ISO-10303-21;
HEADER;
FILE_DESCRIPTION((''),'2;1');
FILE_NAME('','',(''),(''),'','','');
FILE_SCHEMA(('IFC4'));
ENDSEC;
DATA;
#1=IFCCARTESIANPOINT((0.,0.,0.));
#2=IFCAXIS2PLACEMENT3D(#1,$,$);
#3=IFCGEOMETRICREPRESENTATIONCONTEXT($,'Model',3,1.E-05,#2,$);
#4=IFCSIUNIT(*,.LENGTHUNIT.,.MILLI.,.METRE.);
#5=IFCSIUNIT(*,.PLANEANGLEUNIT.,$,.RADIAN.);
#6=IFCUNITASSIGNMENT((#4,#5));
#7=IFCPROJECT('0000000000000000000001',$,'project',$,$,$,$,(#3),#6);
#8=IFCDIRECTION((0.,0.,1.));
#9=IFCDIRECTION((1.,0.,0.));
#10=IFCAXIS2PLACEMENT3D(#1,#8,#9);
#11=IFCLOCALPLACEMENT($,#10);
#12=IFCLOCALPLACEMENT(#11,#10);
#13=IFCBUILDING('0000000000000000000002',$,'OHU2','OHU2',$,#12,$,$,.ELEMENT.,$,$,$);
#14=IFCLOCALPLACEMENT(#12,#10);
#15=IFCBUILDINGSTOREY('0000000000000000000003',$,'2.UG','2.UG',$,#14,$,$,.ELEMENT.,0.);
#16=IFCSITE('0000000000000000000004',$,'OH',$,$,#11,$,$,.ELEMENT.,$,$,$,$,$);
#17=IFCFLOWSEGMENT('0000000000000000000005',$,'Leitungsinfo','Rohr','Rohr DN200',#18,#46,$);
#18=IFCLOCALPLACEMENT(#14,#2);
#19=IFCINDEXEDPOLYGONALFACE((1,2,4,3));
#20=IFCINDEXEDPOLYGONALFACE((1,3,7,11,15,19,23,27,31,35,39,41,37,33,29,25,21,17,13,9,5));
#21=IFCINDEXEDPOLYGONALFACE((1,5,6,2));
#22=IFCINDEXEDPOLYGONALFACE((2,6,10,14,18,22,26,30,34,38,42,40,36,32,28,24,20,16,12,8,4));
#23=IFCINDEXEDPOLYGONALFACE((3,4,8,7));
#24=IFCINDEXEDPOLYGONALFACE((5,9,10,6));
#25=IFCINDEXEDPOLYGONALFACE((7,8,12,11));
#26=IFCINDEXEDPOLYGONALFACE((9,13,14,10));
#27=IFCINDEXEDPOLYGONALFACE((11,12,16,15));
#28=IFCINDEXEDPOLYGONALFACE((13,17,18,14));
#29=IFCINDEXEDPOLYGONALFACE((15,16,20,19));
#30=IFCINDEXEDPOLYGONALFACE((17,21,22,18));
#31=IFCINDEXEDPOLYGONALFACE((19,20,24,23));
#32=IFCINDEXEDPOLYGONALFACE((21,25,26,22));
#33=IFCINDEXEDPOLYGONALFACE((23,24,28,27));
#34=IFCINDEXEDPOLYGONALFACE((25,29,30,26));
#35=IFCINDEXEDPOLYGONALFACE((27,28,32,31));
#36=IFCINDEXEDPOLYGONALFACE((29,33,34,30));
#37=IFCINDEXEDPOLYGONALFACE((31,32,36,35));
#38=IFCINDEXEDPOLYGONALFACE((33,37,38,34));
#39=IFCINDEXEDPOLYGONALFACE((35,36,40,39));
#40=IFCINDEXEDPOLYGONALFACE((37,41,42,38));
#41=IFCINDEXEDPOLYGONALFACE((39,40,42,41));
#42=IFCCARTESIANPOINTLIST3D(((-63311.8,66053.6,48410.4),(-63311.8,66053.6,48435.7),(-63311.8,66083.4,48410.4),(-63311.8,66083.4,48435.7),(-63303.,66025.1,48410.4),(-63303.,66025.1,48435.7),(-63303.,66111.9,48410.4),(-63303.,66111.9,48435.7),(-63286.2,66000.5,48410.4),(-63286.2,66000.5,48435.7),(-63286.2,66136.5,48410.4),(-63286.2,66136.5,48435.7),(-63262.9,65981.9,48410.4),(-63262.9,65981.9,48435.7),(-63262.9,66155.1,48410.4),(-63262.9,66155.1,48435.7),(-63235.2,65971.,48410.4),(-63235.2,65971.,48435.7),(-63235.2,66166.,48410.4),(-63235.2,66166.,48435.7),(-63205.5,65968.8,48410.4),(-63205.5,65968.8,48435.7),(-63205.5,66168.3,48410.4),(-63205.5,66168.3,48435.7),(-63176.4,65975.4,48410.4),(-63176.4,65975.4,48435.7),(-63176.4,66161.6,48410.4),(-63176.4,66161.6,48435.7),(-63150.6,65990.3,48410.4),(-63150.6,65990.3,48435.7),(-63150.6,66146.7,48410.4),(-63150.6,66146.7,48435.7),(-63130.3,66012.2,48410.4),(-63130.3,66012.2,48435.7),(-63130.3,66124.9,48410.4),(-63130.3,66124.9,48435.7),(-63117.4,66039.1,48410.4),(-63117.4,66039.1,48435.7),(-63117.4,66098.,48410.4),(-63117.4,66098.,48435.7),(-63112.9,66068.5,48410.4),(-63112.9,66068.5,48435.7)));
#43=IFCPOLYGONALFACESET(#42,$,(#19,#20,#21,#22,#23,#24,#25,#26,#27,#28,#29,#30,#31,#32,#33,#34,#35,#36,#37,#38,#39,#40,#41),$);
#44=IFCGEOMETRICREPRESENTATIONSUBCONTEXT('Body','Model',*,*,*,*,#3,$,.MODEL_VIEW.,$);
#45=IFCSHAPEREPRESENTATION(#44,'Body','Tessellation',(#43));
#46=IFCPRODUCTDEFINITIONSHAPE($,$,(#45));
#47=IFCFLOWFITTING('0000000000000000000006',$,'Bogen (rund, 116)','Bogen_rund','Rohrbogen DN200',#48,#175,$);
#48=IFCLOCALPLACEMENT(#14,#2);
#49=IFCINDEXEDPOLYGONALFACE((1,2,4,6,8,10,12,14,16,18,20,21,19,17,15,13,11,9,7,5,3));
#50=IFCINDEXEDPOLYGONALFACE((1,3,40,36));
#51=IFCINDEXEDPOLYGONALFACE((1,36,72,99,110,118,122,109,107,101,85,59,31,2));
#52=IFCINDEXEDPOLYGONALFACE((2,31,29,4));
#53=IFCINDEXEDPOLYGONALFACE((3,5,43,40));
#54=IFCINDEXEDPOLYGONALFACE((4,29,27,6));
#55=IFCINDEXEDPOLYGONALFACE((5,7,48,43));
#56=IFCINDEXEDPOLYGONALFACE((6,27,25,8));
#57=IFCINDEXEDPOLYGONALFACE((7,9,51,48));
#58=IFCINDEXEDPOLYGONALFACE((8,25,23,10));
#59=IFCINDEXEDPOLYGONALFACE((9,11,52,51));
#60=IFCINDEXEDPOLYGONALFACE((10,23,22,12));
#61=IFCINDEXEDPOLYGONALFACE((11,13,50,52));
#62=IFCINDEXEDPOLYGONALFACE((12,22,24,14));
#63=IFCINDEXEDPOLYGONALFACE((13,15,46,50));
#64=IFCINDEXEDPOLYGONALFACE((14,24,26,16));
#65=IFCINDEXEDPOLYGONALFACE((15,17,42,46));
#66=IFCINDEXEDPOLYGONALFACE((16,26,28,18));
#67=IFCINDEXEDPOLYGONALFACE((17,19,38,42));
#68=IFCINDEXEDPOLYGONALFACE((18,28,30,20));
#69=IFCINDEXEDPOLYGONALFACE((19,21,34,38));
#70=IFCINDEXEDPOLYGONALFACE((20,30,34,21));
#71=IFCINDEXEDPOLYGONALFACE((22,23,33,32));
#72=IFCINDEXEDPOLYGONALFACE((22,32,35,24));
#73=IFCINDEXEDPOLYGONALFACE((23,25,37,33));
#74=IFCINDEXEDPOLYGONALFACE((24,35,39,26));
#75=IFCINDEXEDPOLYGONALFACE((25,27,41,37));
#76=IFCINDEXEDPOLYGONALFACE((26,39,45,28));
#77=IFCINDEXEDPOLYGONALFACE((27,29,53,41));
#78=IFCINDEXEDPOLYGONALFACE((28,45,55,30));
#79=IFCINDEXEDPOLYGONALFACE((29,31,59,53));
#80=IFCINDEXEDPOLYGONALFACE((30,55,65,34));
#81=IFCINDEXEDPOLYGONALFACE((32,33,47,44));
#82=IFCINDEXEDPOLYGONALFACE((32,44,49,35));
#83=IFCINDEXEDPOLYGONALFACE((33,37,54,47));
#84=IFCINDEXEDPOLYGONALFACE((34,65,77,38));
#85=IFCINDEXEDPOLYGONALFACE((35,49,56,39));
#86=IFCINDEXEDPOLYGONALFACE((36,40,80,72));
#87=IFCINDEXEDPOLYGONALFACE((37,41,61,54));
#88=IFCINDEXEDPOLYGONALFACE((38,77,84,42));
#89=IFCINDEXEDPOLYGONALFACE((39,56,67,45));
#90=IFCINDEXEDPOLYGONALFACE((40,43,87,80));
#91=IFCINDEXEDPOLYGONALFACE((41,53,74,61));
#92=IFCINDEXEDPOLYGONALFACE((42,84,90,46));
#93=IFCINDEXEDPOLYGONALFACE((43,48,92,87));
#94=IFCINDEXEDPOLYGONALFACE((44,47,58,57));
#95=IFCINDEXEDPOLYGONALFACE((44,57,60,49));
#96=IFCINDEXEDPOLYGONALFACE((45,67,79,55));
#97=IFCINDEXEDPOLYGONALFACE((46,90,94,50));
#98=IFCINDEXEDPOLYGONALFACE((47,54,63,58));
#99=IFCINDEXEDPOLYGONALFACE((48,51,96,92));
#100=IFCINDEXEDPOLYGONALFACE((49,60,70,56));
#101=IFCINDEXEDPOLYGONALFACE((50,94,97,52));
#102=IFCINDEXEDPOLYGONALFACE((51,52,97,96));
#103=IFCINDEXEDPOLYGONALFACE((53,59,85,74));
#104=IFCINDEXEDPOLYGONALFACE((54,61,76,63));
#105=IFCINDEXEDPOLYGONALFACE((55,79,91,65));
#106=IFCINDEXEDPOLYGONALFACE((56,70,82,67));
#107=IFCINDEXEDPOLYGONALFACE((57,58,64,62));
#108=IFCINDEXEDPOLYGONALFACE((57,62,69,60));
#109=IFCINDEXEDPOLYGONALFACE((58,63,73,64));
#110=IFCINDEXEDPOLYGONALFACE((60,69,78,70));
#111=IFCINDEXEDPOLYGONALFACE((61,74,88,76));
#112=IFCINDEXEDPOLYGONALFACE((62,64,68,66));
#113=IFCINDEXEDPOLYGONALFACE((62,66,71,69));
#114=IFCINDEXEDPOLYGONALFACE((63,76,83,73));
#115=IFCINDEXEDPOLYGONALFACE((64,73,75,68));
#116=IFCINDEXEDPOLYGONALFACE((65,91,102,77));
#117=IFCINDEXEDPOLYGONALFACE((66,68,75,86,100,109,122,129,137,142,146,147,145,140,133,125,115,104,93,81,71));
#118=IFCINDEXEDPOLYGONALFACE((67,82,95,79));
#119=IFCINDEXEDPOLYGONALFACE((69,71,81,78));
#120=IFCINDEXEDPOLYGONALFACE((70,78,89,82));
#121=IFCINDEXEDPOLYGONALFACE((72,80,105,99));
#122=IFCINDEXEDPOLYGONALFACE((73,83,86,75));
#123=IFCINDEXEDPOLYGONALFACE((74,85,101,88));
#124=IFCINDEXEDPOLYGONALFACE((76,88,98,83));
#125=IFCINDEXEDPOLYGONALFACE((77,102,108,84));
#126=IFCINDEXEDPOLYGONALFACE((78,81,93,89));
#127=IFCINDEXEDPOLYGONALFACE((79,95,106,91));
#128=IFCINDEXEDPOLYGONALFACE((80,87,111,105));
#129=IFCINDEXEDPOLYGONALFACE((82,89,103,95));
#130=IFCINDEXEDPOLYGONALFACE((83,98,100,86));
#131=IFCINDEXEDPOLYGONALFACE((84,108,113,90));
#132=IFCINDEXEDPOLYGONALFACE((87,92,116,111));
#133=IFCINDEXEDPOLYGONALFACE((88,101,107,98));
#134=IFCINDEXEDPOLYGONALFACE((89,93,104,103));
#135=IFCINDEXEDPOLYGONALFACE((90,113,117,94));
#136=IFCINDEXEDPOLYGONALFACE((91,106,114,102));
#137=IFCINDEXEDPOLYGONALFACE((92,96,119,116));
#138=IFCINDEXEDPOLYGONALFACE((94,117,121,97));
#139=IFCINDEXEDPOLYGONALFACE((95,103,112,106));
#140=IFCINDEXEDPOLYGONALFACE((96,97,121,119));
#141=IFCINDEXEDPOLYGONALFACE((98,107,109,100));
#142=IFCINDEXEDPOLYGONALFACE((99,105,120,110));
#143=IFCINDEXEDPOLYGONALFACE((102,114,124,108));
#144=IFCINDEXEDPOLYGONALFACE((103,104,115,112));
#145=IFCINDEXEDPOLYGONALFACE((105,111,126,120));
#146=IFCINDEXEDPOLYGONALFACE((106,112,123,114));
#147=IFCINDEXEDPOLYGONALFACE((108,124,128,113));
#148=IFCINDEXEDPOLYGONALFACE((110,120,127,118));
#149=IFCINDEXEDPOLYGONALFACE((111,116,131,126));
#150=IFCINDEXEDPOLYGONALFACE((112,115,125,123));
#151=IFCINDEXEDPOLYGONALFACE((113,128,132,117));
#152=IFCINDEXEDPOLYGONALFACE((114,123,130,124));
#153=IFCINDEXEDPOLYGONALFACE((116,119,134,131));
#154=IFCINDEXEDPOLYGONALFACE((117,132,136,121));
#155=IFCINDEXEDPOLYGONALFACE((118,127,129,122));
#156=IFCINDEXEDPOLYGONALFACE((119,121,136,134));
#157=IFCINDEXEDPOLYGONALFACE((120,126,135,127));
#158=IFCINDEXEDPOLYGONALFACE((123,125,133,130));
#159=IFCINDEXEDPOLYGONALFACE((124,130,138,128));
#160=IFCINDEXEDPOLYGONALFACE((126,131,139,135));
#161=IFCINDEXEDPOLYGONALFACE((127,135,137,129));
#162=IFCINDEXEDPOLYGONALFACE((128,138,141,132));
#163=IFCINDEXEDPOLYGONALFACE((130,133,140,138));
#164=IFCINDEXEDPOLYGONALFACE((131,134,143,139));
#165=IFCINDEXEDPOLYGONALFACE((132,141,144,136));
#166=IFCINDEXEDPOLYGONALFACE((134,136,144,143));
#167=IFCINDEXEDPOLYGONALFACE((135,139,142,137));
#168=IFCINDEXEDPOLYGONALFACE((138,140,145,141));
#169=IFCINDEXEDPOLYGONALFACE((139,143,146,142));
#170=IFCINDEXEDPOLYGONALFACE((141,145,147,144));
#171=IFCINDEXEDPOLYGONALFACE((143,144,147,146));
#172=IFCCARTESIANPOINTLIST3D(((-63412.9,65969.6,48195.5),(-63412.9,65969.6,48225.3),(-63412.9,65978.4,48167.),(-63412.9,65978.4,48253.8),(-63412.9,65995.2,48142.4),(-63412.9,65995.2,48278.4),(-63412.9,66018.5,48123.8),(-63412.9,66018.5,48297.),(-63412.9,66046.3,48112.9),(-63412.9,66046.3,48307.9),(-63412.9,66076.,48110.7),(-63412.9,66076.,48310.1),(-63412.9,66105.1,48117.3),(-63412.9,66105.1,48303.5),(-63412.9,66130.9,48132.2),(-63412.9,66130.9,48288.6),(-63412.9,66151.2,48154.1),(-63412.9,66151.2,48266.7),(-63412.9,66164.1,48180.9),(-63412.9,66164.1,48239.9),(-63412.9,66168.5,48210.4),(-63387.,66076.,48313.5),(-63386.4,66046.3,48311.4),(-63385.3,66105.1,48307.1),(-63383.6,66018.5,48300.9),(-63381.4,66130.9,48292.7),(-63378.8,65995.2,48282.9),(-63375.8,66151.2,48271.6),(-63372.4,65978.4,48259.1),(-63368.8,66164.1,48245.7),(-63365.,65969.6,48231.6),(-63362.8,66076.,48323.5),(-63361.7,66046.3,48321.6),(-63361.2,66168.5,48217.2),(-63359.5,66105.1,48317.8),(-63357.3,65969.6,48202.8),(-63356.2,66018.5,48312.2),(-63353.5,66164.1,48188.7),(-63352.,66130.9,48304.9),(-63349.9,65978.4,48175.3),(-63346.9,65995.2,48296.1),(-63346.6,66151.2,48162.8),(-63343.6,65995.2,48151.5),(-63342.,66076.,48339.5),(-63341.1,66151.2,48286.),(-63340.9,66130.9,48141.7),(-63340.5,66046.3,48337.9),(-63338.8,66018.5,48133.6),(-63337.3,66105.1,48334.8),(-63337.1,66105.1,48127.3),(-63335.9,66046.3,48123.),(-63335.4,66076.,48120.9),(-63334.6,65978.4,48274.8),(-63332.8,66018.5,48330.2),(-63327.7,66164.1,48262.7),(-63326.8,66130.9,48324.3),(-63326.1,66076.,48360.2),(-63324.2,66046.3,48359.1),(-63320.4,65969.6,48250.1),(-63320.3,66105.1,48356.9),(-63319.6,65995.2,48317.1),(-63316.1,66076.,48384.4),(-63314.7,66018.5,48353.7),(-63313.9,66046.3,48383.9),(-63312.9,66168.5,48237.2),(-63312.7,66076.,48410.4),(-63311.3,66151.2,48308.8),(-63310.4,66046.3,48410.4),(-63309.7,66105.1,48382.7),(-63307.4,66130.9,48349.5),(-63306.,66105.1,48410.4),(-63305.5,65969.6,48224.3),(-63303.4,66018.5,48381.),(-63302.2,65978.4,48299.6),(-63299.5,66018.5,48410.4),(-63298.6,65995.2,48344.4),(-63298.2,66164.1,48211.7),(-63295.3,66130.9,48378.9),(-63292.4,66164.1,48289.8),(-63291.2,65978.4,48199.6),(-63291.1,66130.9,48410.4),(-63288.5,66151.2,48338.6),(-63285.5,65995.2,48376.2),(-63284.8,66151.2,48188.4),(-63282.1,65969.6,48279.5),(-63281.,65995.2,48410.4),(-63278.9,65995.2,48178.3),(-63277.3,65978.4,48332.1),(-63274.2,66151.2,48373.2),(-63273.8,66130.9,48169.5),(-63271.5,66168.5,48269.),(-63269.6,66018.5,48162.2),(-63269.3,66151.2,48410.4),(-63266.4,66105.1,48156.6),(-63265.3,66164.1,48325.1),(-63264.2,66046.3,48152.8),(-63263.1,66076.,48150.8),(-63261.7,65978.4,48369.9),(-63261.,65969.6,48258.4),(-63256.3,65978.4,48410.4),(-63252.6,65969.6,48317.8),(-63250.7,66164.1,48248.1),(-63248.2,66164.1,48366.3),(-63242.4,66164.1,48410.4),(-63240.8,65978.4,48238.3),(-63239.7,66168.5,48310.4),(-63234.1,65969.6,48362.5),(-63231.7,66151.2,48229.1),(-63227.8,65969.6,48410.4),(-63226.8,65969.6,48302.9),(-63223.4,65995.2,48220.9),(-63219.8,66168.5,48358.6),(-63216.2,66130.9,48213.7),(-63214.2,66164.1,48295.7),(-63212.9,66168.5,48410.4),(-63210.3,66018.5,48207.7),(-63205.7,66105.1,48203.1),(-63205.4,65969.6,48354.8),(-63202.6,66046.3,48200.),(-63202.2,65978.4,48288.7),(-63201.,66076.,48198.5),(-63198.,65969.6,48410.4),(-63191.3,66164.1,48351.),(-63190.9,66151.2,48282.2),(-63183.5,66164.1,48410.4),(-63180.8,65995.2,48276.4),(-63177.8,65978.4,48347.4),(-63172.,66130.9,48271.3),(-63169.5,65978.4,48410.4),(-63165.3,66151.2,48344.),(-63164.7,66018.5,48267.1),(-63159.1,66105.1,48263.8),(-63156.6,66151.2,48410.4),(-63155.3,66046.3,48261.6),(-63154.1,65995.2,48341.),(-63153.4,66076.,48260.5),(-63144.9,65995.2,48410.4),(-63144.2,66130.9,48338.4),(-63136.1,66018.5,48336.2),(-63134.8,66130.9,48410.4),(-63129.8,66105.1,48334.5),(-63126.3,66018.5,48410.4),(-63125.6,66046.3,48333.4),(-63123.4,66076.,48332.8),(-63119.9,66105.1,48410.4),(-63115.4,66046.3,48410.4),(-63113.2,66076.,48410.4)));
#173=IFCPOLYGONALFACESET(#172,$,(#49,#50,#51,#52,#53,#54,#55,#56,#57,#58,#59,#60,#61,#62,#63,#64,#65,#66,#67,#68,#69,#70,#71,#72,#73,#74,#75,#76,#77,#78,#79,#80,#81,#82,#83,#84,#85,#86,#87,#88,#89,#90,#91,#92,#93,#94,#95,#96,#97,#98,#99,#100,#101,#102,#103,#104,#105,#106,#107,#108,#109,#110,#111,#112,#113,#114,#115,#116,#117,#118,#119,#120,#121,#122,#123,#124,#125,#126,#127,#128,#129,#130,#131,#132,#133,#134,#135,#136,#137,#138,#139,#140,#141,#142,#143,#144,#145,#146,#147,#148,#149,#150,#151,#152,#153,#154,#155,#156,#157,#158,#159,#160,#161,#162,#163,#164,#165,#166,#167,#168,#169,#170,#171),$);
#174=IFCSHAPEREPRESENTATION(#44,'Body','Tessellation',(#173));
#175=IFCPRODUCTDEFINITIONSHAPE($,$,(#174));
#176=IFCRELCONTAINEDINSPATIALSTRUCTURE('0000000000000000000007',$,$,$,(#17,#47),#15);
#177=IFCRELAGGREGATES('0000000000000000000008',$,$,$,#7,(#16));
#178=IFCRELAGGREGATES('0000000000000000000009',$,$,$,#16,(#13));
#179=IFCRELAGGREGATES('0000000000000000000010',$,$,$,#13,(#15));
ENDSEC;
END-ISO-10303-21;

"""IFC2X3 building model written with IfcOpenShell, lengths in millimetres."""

from ifc_helpers import new_model, entity, si_unit, frame, origin, origin_with_axes, origin_2d_with_axis, place, context, subcontext, project, spatial, circle, extrude, element, save


model = new_model("IFC2X3")

# Units and contexts
model_context = context("Model", 3, precision=1e-05, world=origin())
body_context = subcontext(model_context, "Body", "Model", "MODEL_VIEW")
ifc_project = project(units=[si_unit("LENGTHUNIT", "METRE", prefix="MILLI"), si_unit("PLANEANGLEUNIT", "RADIAN")], contexts=[model_context])

# Site, building, storey
site_placement = place(None, origin_with_axes())
site = spatial("IfcSite", under=ifc_project, at=site_placement, Name="OH", CompositionType="ELEMENT")
building_placement = place(site_placement, origin_with_axes())
building = spatial("IfcBuilding", under=site, at=building_placement, Name="OHU2", Description="OHU2", CompositionType="ELEMENT")
storey_placement = place(building_placement, origin_with_axes())
storey = spatial("IfcBuildingStorey", under=building, at=storey_placement, Name="2.UG", Description="2.UG", CompositionType="ELEMENT", Elevation=0.0)

# Flow segment
flow_segment_1_placement = place(storey_placement, frame((-63212.9, 66068.4, 48423.0), z_axis=(0.0, 0.0, 1.0), x_axis=(1.0, 0.0, 0.0)))
element("IfcFlowSegment", 1, at=flow_segment_1_placement, inside=storey, Name="Leitungsinfo", Description="Rohr", ObjectType="Rohr DN200", context=body_context, shape_type="SweptSolid", body=[
    extrude(circle(Radius=100.0, at=origin_2d_with_axis()), frame((0.0, 0.2, -12.6), z_axis=(0.000019, -0.000006, 1.0), x_axis=(1.0, 0.0, 0.0)), (0.0, 0.0, 1.0), 25.3),
])

# Flow fitting
flow_fitting_1_placement = place(storey_placement, frame((-63262.9, 66068.5, 48260.4), z_axis=(0.0, 0.0, 1.0), x_axis=(1.0, 0.0, 0.0)))
element("IfcFlowFitting", 2, at=flow_fitting_1_placement, inside=storey, Name="Bogen (rund, 116)", Description="Bogen_rund", ObjectType="Rohrbogen DN200", context=body_context, shape_type="SweptSolid", body=[
    entity("IfcRevolvedAreaSolid", entity("IfcCircleProfileDef", "AREA", None, entity("IfcAxis2Placement2D", entity("IfcCartesianPoint", [0.0, 0.0]), entity("IfcDirection", [1.0, 0.0])), 100.0), entity("IfcAxis2Placement3D", entity("IfcCartesianPoint", [-150.0, 0.0, -50.0]), entity("IfcDirection", [1.0, 0.0, 0.0]), entity("IfcDirection", [0.0, 1.0, 0.000006])), entity("IfcAxis1Placement", entity("IfcCartesianPoint", [0.0, 200.0, 0.0]), entity("IfcDirection", [-1.0, 0.0, 0.0])), 1.570796),
])

save(model, "model.ifc")
